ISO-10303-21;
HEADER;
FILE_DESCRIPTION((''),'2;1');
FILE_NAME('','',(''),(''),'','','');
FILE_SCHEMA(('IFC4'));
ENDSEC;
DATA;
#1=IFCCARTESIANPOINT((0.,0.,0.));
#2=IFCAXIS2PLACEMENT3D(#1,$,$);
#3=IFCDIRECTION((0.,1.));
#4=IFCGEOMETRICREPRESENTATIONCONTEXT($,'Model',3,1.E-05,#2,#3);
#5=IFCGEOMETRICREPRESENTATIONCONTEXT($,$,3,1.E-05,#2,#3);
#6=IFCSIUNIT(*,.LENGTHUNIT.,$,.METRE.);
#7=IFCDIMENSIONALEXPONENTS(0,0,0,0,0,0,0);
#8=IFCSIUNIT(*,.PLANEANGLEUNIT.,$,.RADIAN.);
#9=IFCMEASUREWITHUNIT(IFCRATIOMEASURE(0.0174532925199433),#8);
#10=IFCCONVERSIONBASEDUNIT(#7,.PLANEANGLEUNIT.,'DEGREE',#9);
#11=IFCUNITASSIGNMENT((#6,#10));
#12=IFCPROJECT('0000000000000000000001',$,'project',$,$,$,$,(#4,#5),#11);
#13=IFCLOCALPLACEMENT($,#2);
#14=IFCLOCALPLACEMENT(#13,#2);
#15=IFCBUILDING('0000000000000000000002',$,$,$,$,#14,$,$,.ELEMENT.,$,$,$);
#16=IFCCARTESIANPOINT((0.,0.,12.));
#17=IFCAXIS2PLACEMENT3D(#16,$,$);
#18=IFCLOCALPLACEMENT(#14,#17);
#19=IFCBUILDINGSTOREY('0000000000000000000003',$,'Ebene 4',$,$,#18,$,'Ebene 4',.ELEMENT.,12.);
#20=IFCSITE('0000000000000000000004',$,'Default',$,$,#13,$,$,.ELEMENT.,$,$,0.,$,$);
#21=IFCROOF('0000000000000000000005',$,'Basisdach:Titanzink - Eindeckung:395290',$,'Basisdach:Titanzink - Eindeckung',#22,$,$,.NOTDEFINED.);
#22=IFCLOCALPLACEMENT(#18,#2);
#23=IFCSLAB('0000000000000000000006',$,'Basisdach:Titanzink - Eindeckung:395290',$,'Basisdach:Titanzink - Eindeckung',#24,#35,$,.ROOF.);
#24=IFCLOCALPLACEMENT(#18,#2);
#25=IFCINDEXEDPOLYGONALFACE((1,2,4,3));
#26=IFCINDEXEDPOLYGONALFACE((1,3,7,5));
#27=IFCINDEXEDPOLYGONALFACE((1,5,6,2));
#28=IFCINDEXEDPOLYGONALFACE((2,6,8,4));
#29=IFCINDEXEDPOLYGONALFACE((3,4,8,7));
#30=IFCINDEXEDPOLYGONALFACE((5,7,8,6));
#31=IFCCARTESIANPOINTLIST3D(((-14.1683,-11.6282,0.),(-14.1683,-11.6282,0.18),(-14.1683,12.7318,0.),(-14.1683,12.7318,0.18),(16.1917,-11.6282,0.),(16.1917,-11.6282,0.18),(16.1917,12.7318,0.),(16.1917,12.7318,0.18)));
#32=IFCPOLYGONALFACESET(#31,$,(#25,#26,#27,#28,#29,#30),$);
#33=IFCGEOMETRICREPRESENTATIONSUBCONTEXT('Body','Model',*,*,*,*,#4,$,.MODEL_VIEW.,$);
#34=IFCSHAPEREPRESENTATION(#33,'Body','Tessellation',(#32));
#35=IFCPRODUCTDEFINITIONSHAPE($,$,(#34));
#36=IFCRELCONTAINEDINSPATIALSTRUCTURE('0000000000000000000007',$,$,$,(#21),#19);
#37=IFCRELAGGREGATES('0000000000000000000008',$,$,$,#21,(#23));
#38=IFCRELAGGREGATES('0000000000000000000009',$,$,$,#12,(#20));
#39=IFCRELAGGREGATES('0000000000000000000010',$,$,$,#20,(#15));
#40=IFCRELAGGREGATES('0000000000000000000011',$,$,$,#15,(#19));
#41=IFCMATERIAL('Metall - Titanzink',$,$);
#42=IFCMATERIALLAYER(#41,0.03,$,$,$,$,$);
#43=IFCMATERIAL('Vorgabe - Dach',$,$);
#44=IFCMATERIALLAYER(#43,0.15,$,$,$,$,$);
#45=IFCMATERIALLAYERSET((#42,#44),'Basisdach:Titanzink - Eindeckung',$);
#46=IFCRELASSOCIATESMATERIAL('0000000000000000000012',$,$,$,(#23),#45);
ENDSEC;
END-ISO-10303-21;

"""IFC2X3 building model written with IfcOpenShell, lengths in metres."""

from ifc_helpers import new_model, entity, si_unit, converted_unit, direction, frame, frame_2d, origin, place, context, subcontext, project, spatial, rectangle, extrude, material, layer, layer_set, element, aggregate, save


model = new_model("IFC2X3")

# Units and contexts
model_context = context("Model", 3, precision=1e-05, world=origin(), true_north=direction((0.0, 1.0)))
context_of_model = context(None, 3, precision=1e-05, world=origin(), true_north=direction((0.0, 1.0)))
body_context = subcontext(model_context, "Body", "Model", "MODEL_VIEW")
ifc_project = project(units=[si_unit("LENGTHUNIT", "METRE"), converted_unit("PLANEANGLEUNIT", "DEGREE", entity("IfcRatioMeasure", 0.0174532925199433), si_unit("PLANEANGLEUNIT", "RADIAN"), dimensions=[0, 0, 0, 0, 0, 0, 0])], contexts=[model_context, context_of_model])

# Site, building, storey
site_placement = place(None, origin())
site = spatial("IfcSite", under=ifc_project, at=site_placement, Name="Default", CompositionType="ELEMENT", RefElevation=0.0)
building_placement = place(site_placement, origin())
building = spatial("IfcBuilding", under=site, at=building_placement, CompositionType="ELEMENT")
storey_placement = place(building_placement, frame((0.0, 0.0, 12.0)))
storey = spatial("IfcBuildingStorey", under=building, at=storey_placement, Name="Ebene 4", LongName="Ebene 4", CompositionType="ELEMENT", Elevation=12.0)

# Roof, slab
roof_placement = place(storey_placement, frame((-14.1683, -11.6282, 0.0)))
roof = element("IfcRoof", 1, at=roof_placement, inside=storey, Name="Basisdach:Titanzink - Eindeckung:395290", ObjectType="Basisdach:Titanzink - Eindeckung", ShapeType="NOTDEFINED")
ifc_material_1 = material(Name="Metall - Titanzink")
ifc_layer_1 = layer(ifc_material_1, 0.03)
ifc_material_2 = material(Name="Vorgabe - Dach")
ifc_layer_2 = layer(ifc_material_2, 0.15)
ifc_layer_set = layer_set([ifc_layer_1, ifc_layer_2], Name="Basisdach:Titanzink - Eindeckung")
slab_placement = place(roof_placement, origin())
slab = element("IfcSlab", 2, at=slab_placement, material=ifc_layer_set, Name="Basisdach:Titanzink - Eindeckung:395290", ObjectType="Basisdach:Titanzink - Eindeckung", PredefinedType="ROOF", context=body_context, shape_type="SweptSolid", body=[
    extrude(rectangle(XDim=30.36, YDim=24.36, at=frame_2d((0.0, 0.0), x_axis=(-1.0, 0.0))), frame((15.18, 12.18, 0.0)), (0.0, 0.0, 1.0), 0.18),
])
aggregate(roof, [slab])

save(model, "model.ifc")
